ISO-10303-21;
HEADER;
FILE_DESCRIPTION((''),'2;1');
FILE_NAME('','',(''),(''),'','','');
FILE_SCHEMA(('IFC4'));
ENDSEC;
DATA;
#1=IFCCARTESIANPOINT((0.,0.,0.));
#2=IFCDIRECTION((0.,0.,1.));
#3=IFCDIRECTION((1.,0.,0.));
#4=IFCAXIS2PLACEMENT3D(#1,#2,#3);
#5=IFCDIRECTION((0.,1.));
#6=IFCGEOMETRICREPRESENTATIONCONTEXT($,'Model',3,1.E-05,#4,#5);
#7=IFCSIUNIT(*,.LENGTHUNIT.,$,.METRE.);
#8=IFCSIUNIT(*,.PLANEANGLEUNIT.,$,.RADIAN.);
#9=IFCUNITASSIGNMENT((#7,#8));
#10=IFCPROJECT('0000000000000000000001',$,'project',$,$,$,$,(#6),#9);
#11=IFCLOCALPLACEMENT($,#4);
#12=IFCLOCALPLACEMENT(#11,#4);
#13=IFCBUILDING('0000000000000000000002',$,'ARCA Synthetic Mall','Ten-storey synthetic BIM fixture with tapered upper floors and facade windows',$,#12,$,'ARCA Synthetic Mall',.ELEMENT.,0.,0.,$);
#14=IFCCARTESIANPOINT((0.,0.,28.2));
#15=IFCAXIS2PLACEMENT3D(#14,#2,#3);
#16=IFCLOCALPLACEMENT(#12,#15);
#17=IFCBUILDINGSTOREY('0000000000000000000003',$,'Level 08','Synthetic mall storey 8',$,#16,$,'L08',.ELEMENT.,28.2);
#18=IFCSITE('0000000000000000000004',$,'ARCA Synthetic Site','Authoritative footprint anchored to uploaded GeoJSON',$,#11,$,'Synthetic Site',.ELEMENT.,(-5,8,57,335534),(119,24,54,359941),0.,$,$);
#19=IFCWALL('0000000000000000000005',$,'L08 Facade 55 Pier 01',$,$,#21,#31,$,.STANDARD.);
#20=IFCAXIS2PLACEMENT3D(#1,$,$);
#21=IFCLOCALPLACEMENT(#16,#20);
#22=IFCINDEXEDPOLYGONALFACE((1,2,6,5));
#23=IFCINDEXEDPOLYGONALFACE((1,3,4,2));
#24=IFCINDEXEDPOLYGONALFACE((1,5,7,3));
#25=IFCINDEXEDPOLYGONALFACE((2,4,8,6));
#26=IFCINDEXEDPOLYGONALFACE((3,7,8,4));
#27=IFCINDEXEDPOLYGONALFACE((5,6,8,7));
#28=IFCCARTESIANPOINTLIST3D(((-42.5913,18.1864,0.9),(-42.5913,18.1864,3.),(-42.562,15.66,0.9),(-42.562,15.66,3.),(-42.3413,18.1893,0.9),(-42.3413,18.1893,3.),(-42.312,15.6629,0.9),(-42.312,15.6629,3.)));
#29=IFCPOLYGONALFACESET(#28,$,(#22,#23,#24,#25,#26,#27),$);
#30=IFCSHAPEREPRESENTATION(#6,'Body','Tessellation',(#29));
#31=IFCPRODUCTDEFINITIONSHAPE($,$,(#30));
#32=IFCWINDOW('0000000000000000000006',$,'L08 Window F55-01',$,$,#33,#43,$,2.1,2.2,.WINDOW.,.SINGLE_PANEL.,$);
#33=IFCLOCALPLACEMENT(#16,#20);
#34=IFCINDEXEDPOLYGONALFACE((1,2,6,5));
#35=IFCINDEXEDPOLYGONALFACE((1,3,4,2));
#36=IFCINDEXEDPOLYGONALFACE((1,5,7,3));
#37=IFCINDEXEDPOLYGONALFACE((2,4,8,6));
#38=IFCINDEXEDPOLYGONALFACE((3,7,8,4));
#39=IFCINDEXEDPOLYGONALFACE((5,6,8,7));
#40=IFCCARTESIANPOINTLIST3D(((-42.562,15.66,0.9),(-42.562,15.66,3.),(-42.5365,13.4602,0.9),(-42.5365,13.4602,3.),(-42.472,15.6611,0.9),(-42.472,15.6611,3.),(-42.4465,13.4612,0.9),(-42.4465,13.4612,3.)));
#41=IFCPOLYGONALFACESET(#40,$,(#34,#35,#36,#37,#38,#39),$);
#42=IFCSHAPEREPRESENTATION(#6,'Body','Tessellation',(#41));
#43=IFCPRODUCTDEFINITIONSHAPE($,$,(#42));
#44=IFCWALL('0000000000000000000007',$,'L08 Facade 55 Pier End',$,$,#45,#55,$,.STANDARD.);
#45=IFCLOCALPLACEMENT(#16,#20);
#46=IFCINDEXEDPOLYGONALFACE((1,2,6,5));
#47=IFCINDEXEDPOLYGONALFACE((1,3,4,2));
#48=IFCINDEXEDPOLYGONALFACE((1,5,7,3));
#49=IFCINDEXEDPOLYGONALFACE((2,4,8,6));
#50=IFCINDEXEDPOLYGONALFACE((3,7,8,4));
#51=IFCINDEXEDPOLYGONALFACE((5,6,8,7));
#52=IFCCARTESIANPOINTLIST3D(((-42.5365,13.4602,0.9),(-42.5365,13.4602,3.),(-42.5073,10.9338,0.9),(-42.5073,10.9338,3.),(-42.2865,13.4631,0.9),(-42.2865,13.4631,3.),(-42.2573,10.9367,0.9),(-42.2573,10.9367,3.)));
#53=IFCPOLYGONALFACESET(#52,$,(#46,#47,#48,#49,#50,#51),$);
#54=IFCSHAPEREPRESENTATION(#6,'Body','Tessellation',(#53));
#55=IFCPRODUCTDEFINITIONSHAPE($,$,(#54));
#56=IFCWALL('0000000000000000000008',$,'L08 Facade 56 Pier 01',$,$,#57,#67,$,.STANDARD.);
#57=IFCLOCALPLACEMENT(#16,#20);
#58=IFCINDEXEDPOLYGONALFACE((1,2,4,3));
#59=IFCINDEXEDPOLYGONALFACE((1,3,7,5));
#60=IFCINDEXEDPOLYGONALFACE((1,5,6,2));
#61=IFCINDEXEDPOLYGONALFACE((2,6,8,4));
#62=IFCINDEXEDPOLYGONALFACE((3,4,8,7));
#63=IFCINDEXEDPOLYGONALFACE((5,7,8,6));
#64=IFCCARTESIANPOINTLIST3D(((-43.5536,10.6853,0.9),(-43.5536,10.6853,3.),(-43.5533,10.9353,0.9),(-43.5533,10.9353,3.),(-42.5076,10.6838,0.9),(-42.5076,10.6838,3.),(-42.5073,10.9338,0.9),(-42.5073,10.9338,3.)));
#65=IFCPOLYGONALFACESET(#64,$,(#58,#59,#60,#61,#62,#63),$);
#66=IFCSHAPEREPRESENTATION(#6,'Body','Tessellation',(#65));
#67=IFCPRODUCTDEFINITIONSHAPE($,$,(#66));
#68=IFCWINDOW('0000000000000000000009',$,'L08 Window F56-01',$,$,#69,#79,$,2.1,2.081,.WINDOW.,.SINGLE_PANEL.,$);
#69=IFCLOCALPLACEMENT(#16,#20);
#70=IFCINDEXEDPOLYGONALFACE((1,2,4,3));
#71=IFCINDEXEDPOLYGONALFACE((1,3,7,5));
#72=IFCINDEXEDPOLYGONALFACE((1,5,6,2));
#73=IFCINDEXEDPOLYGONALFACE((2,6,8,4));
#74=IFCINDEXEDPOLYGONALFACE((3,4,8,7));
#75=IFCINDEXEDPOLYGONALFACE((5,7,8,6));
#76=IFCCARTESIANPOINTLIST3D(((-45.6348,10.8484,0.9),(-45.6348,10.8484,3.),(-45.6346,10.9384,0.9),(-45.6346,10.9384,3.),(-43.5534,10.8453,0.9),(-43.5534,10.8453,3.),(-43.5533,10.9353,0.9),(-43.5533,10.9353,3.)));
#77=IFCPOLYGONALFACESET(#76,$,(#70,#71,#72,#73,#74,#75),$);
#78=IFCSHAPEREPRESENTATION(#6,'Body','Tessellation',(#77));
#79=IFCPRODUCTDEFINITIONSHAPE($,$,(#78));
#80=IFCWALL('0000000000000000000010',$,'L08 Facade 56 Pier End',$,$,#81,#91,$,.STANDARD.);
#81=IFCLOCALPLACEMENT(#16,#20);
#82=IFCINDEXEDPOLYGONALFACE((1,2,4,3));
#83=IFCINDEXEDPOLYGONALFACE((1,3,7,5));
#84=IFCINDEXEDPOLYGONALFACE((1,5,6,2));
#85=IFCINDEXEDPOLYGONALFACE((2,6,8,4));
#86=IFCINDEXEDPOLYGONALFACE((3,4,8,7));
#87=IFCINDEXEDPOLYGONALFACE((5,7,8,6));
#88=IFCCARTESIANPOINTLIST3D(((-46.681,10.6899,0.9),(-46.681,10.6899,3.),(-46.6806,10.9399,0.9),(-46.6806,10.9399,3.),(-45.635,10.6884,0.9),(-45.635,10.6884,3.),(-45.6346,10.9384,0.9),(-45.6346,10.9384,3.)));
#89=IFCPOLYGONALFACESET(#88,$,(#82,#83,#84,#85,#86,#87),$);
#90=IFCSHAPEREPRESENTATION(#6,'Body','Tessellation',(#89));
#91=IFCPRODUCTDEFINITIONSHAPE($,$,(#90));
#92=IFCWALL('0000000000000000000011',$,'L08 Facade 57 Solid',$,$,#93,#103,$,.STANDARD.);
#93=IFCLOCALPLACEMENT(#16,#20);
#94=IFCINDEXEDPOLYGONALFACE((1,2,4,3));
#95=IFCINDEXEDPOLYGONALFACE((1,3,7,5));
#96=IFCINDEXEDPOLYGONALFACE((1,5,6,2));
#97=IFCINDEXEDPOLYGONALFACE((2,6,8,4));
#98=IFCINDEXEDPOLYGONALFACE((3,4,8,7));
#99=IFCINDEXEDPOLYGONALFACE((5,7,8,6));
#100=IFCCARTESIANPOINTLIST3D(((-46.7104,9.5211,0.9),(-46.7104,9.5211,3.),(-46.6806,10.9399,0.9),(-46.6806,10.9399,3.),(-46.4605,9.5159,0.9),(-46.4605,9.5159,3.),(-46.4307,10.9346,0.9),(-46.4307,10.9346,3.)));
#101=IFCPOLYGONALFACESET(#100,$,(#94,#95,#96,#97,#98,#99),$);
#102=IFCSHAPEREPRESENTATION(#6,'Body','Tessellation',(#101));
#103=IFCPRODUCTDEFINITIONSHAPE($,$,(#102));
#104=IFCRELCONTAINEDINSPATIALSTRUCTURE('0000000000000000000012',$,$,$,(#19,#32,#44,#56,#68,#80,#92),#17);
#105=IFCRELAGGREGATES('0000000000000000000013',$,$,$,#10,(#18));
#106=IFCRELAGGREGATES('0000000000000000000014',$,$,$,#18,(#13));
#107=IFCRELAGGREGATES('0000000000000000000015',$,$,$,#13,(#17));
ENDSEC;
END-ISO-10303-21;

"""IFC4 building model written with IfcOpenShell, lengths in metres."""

from ifc_helpers import new_model, si_unit, direction, frame, origin_with_axes, place, context, project, spatial, polyline, outline, extrude, element, save


model = new_model("IFC4")

# Units and contexts
model_context = context("Model", 3, precision=1e-05, world=origin_with_axes(), true_north=direction((0.0, 1.0)))
ifc_project = project(units=[si_unit("LENGTHUNIT", "METRE"), si_unit("PLANEANGLEUNIT", "RADIAN")], contexts=[model_context])

# Site, building, storey
site_placement = place(None, origin_with_axes())
site = spatial("IfcSite", under=ifc_project, at=site_placement, Name="ARCA Synthetic Site", Description="Authoritative footprint anchored to uploaded GeoJSON", LongName="Synthetic Site", CompositionType="ELEMENT", RefLatitude=(-5, 8, 57, 335534), RefLongitude=(119, 24, 54, 359941), RefElevation=0.0)
building_placement = place(site_placement, origin_with_axes())
building = spatial("IfcBuilding", under=site, at=building_placement, Name="ARCA Synthetic Mall", Description="Ten-storey synthetic BIM fixture with tapered upper floors and facade windows", LongName="ARCA Synthetic Mall", CompositionType="ELEMENT", ElevationOfRefHeight=0.0, ElevationOfTerrain=0.0)
storey_placement = place(building_placement, frame((0.0, 0.0, 28.2), z_axis=(0.0, 0.0, 1.0), x_axis=(1.0, 0.0, 0.0)))
storey = spatial("IfcBuildingStorey", under=building, at=storey_placement, Name="Level 08", Description="Synthetic mall storey 8", LongName="L08", CompositionType="ELEMENT", Elevation=28.2)

# Wall
wall_1_placement = place(storey_placement, frame((0.0, 0.0, 0.9), z_axis=(0.0, 0.0, 1.0), x_axis=(1.0, 0.0, 0.0)))
element("IfcWall", 1, at=wall_1_placement, inside=storey, Name="L08 Facade 55 Pier 01", PredefinedType="STANDARD", context=model_context, shape_type="SweptSolid", body=[
    extrude(outline(polyline([(-42.5913, 18.1864), (-42.562, 15.66), (-42.312, 15.6629), (-42.3413, 18.1893), (-42.5913, 18.1864)])), origin_with_axes(), (0.0, 0.0, 1.0), 2.1),
])

# Window
window_1_placement = place(storey_placement, frame((0.0, 0.0, 0.9), z_axis=(0.0, 0.0, 1.0), x_axis=(1.0, 0.0, 0.0)))
element("IfcWindow", 2, at=window_1_placement, inside=storey, Name="L08 Window F55-01", OverallHeight=2.1, OverallWidth=2.2, PartitioningType="SINGLE_PANEL", PredefinedType="WINDOW", context=model_context, shape_type="SweptSolid", body=[
    extrude(outline(polyline([(-42.562, 15.66), (-42.5365, 13.4602), (-42.4465, 13.4612), (-42.472, 15.6611), (-42.562, 15.66)])), origin_with_axes(), (0.0, 0.0, 1.0), 2.1),
])

# Walls
wall_2_placement = place(storey_placement, frame((0.0, 0.0, 0.9), z_axis=(0.0, 0.0, 1.0), x_axis=(1.0, 0.0, 0.0)))
element("IfcWall", 3, at=wall_2_placement, inside=storey, Name="L08 Facade 55 Pier End", PredefinedType="STANDARD", context=model_context, shape_type="SweptSolid", body=[
    extrude(outline(polyline([(-42.5365, 13.4602), (-42.5073, 10.9338), (-42.2573, 10.9367), (-42.2865, 13.4631), (-42.5365, 13.4602)])), origin_with_axes(), (0.0, 0.0, 1.0), 2.1),
])
wall_3_placement = place(storey_placement, frame((0.0, 0.0, 0.9), z_axis=(0.0, 0.0, 1.0), x_axis=(1.0, 0.0, 0.0)))
element("IfcWall", 4, at=wall_3_placement, inside=storey, Name="L08 Facade 56 Pier 01", PredefinedType="STANDARD", context=model_context, shape_type="SweptSolid", body=[
    extrude(outline(polyline([(-42.5073, 10.9338), (-43.5533, 10.9353), (-43.5536, 10.6853), (-42.5076, 10.6838), (-42.5073, 10.9338)])), origin_with_axes(), (0.0, 0.0, 1.0), 2.1),
])

# Window
window_2_placement = place(storey_placement, frame((0.0, 0.0, 0.9), z_axis=(0.0, 0.0, 1.0), x_axis=(1.0, 0.0, 0.0)))
element("IfcWindow", 5, at=window_2_placement, inside=storey, Name="L08 Window F56-01", OverallHeight=2.1, OverallWidth=2.081, PartitioningType="SINGLE_PANEL", PredefinedType="WINDOW", context=model_context, shape_type="SweptSolid", body=[
    extrude(outline(polyline([(-43.5533, 10.9353), (-45.6346, 10.9384), (-45.6348, 10.8484), (-43.5534, 10.8453), (-43.5533, 10.9353)])), origin_with_axes(), (0.0, 0.0, 1.0), 2.1),
])

# Walls
wall_4_placement = place(storey_placement, frame((0.0, 0.0, 0.9), z_axis=(0.0, 0.0, 1.0), x_axis=(1.0, 0.0, 0.0)))
element("IfcWall", 6, at=wall_4_placement, inside=storey, Name="L08 Facade 56 Pier End", PredefinedType="STANDARD", context=model_context, shape_type="SweptSolid", body=[
    extrude(outline(polyline([(-45.6346, 10.9384), (-46.6806, 10.9399), (-46.681, 10.6899), (-45.635, 10.6884), (-45.6346, 10.9384)])), origin_with_axes(), (0.0, 0.0, 1.0), 2.1),
])
wall_5_placement = place(storey_placement, frame((0.0, 0.0, 0.9), z_axis=(0.0, 0.0, 1.0), x_axis=(1.0, 0.0, 0.0)))
element("IfcWall", 7, at=wall_5_placement, inside=storey, Name="L08 Facade 57 Solid", PredefinedType="STANDARD", context=model_context, shape_type="SweptSolid", body=[
    extrude(outline(polyline([(-46.6806, 10.9399), (-46.7104, 9.5211), (-46.4605, 9.5159), (-46.4307, 10.9346), (-46.6806, 10.9399)])), origin_with_axes(), (0.0, 0.0, 1.0), 2.1),
])

save(model, "model.ifc")
